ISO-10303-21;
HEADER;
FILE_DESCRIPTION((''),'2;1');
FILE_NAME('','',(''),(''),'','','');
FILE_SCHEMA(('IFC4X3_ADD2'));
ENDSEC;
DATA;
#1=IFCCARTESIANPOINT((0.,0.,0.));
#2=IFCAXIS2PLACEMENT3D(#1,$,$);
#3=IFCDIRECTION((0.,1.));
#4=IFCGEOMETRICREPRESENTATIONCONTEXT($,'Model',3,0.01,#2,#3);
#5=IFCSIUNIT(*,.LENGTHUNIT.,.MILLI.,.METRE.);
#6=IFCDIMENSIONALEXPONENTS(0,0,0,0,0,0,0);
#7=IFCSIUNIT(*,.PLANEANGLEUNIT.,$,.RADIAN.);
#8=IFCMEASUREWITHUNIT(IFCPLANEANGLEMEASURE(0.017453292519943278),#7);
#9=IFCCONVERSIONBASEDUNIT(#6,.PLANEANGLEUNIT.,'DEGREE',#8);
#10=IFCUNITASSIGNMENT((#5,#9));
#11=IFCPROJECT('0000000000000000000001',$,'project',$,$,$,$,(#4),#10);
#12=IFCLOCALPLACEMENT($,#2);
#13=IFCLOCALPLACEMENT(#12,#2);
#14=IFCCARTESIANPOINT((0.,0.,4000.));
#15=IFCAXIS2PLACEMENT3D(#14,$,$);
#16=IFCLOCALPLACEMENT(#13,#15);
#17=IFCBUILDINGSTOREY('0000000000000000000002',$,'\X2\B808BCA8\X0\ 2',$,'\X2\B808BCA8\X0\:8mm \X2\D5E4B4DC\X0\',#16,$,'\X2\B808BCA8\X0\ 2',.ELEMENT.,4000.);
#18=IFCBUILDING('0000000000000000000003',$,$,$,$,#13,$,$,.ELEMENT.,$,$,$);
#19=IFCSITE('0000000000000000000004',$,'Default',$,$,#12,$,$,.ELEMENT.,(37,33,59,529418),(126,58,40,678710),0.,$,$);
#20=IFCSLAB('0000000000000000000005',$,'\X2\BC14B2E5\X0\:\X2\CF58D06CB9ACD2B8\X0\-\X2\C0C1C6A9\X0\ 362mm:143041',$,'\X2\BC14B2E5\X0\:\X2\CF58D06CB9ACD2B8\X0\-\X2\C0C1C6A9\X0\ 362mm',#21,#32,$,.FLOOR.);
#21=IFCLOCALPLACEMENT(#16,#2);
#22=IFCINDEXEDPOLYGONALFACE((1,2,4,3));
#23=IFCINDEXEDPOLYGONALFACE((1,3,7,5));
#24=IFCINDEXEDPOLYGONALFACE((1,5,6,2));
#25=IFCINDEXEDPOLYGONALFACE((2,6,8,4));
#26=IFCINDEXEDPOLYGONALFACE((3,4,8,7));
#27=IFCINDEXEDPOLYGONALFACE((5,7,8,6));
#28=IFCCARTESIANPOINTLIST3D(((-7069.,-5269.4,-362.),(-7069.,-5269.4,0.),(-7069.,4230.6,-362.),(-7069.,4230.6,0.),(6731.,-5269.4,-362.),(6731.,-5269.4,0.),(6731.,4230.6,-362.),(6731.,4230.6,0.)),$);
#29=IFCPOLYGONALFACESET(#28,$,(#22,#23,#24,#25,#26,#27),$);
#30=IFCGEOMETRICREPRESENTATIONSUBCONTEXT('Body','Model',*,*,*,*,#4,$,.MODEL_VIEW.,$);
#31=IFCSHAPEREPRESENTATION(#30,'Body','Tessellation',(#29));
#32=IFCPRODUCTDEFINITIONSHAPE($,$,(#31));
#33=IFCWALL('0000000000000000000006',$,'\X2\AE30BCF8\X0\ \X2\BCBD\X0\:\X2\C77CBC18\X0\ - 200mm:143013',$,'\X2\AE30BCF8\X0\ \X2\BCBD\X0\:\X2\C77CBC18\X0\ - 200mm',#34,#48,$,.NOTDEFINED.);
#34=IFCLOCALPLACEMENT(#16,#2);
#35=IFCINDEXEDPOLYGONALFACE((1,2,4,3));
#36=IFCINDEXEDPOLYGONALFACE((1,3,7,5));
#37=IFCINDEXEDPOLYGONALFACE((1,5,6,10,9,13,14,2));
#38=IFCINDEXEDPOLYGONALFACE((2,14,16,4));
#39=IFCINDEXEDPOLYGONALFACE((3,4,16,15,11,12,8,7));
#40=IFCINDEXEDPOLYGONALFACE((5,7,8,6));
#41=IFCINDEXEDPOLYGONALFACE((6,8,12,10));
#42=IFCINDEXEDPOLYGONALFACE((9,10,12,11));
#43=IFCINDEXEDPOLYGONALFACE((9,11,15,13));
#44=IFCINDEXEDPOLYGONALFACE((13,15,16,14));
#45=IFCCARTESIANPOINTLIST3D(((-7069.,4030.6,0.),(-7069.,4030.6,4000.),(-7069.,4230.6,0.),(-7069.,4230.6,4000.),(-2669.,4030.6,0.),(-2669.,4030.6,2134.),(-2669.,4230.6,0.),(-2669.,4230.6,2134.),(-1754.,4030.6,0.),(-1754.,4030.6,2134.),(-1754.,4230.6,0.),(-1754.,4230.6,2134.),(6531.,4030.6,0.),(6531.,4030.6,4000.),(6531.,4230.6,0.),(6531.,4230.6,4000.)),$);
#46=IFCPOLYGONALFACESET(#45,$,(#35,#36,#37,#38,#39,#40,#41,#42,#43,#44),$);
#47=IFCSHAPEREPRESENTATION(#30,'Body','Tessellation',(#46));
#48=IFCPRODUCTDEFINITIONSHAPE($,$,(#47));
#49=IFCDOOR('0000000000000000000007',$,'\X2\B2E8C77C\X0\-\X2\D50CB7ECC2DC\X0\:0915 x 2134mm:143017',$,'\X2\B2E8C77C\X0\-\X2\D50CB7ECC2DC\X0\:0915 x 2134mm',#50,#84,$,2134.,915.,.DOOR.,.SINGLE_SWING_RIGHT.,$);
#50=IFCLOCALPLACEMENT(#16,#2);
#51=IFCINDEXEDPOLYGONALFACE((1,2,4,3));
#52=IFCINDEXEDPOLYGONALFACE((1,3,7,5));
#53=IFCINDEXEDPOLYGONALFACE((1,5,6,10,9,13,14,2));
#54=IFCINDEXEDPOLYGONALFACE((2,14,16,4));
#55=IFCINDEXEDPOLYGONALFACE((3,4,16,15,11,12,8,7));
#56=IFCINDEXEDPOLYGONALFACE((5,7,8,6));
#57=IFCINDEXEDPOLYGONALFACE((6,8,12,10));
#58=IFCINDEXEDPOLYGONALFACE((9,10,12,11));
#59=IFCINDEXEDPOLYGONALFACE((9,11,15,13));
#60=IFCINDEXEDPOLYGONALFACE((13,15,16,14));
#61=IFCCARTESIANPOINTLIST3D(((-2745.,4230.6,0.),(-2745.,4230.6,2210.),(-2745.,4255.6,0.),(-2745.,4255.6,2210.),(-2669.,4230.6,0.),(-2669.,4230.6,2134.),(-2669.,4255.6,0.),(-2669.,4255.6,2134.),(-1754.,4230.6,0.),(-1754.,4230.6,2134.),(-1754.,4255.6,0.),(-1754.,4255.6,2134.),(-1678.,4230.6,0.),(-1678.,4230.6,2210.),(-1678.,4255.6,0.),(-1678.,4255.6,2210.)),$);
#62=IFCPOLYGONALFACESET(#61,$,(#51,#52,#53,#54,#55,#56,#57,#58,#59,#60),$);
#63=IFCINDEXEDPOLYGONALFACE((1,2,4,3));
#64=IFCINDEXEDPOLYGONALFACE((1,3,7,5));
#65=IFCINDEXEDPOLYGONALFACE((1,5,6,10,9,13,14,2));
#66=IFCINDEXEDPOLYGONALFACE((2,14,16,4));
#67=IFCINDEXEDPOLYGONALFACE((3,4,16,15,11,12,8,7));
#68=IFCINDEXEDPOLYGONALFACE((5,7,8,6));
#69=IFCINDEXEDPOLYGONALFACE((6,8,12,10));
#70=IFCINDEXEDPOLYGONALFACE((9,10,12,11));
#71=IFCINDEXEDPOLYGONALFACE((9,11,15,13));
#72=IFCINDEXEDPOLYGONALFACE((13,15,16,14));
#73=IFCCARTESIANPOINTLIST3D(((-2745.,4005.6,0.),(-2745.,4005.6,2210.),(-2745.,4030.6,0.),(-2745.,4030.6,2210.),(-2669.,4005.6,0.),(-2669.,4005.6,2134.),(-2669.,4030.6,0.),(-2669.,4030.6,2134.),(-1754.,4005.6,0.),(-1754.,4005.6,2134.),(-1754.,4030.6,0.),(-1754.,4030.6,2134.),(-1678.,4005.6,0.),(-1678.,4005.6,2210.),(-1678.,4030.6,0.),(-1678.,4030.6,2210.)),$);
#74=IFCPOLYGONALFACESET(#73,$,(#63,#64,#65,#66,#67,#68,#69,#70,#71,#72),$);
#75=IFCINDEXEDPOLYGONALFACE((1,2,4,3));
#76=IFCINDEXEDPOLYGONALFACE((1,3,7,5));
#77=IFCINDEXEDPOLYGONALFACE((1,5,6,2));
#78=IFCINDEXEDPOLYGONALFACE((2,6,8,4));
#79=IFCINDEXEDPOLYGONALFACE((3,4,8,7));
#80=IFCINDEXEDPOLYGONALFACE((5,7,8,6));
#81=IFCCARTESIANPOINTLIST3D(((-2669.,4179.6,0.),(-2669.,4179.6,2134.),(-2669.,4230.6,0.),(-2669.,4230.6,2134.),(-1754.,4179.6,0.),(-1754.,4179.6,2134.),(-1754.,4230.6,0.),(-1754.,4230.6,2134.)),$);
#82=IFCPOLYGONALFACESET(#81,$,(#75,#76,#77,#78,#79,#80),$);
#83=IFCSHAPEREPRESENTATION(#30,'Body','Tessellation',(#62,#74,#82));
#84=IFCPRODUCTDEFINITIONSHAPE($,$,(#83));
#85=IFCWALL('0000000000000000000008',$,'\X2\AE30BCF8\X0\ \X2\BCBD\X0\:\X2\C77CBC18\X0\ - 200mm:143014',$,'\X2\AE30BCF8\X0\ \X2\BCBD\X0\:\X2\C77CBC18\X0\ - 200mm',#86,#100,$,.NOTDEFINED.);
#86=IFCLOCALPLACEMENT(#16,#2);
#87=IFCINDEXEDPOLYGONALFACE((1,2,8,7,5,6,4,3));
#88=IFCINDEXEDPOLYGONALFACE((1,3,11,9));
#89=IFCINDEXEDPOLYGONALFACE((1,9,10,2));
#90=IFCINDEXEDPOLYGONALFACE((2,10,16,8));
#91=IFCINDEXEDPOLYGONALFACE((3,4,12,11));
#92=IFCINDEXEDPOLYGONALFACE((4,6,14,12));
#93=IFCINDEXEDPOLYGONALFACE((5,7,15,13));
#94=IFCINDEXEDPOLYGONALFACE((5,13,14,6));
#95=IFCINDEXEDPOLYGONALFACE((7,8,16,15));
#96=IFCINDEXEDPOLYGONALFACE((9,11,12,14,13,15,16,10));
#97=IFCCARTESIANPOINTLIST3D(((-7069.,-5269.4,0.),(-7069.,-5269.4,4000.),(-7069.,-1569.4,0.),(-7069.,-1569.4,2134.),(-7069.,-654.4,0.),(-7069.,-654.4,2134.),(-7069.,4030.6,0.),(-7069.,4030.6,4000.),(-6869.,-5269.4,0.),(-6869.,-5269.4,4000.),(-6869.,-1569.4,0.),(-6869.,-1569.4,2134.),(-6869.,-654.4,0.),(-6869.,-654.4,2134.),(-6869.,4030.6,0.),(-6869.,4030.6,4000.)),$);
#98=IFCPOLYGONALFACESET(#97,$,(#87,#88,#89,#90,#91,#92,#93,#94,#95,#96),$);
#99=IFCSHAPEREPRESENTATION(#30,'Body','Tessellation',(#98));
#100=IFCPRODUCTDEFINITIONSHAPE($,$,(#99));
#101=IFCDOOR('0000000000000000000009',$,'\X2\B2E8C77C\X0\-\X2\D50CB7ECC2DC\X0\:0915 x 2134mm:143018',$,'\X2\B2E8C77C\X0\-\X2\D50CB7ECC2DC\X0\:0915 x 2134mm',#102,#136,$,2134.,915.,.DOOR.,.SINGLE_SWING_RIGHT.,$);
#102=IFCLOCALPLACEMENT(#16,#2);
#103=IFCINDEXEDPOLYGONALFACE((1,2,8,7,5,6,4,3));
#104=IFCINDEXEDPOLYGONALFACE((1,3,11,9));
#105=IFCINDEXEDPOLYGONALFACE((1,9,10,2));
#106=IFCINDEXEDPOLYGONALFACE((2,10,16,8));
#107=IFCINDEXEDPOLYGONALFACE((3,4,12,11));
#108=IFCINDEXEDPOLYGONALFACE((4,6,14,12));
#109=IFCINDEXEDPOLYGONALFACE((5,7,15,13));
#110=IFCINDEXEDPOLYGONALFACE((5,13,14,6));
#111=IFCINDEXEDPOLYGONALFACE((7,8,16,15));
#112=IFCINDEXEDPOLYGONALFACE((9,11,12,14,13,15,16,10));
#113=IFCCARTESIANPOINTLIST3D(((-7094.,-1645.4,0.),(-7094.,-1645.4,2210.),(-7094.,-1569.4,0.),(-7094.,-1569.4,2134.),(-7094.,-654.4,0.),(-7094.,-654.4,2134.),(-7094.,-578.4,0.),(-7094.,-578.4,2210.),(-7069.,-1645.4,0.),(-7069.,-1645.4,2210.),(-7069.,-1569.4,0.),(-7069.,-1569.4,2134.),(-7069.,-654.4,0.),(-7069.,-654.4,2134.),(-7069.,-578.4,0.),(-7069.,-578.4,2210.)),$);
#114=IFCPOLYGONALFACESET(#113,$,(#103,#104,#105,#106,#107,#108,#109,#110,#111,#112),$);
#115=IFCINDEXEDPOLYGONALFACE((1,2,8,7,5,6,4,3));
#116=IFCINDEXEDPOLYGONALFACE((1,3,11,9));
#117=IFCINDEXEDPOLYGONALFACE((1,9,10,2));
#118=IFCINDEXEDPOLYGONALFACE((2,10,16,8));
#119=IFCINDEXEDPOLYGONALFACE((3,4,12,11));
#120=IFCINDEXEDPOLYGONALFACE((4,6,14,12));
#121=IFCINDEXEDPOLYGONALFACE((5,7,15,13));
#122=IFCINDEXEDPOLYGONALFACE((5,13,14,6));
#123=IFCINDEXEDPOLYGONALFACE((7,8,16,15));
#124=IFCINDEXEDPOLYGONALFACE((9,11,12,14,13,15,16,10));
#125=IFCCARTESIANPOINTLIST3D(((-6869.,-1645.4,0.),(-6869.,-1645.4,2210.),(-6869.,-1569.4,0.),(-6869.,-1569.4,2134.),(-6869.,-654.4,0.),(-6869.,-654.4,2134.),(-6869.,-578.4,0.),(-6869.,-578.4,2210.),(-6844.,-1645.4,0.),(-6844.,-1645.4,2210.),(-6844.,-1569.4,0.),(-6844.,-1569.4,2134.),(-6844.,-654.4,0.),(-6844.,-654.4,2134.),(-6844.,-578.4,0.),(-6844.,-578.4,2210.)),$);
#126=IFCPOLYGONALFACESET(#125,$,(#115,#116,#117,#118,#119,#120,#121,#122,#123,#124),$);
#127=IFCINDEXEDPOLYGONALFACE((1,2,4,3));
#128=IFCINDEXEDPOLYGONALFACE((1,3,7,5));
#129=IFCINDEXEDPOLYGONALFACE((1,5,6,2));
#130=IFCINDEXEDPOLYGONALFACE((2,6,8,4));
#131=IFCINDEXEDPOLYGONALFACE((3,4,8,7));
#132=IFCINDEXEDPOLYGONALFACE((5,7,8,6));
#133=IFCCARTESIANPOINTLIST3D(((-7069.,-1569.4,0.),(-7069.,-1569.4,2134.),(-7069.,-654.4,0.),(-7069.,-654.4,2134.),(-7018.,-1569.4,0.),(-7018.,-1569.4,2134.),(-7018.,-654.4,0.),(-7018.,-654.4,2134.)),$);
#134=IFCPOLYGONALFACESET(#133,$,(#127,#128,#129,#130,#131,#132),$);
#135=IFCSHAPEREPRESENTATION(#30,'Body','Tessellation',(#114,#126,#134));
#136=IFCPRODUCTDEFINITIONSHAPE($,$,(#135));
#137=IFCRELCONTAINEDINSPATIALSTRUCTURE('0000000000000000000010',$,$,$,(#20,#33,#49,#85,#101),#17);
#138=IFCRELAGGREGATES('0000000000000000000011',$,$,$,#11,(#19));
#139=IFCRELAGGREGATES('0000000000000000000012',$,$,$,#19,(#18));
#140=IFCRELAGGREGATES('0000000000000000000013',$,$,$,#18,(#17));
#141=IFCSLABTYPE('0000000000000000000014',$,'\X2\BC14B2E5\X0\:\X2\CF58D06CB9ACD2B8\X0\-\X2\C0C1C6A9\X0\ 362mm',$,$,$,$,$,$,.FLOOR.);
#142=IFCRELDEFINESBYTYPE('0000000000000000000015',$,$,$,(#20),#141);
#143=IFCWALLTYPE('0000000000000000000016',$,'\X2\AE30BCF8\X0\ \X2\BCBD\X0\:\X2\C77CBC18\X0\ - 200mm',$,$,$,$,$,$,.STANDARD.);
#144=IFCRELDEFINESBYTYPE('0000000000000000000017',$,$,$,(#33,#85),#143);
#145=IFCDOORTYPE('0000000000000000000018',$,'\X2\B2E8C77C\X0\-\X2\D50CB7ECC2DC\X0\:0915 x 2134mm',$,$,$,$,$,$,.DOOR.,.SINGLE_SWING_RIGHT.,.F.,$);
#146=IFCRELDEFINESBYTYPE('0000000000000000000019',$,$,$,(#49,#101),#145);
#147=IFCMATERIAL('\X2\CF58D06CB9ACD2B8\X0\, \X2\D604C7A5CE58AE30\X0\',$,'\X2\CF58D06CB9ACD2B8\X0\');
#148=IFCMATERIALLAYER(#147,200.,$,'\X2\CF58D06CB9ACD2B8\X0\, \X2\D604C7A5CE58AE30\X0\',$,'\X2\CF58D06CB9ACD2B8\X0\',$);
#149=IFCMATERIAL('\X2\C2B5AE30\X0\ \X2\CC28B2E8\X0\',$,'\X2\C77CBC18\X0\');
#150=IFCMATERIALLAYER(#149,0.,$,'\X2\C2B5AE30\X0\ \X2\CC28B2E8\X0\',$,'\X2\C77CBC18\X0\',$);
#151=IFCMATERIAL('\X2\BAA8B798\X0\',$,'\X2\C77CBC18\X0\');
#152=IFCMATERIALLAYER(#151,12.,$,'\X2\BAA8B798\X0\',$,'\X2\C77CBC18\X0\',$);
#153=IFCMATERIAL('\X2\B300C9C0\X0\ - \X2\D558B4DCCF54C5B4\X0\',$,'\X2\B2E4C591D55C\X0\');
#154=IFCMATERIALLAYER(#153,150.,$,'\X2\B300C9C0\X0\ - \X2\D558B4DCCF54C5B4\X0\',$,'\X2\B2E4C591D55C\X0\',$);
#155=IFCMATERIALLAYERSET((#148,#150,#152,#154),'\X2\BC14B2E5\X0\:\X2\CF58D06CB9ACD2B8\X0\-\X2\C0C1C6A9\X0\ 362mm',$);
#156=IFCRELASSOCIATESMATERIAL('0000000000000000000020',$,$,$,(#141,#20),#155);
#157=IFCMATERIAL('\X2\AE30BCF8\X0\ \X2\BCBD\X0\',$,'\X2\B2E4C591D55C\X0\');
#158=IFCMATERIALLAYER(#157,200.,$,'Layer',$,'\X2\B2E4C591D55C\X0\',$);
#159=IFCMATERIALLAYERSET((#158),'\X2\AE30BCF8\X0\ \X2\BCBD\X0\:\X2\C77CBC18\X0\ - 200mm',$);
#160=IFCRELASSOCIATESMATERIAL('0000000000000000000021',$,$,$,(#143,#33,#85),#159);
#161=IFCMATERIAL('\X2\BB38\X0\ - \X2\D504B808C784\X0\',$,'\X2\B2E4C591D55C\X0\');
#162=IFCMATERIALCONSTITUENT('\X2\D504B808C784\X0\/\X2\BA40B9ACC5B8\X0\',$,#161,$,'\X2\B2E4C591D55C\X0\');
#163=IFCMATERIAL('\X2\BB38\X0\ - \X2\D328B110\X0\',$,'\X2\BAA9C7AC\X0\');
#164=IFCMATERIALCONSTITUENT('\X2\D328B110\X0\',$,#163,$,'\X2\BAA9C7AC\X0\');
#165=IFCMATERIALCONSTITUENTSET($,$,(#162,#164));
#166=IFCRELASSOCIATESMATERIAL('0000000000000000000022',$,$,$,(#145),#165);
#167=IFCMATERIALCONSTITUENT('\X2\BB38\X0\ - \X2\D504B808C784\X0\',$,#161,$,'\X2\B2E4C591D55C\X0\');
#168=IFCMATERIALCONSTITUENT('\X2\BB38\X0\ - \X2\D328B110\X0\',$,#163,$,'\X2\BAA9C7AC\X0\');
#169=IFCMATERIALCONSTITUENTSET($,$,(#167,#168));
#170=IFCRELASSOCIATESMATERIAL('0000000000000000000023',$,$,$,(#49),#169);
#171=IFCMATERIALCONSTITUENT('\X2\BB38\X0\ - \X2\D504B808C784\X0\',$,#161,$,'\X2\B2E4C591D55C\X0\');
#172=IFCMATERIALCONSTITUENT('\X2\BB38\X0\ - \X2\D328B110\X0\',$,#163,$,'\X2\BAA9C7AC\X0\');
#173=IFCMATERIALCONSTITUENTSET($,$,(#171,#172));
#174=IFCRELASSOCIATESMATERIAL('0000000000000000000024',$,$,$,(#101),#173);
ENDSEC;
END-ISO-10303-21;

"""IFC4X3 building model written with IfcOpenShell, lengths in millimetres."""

from ifc_helpers import new_model, entity, si_unit, converted_unit, direction, frame, frame_2d, origin, origin_2d_with_axis, place, context, subcontext, project, spatial, polyline, rectangle, outline, extrude, source, transform, mapped, material, layer, layer_set, layer_usage, constituent, constituent_set, type_object, type_shapes, element, fill, save


model = new_model("IFC4X3")

# Units and contexts
model_context = context("Model", 3, precision=0.01, world=origin(), true_north=direction((0.0, 1.0)))
body_context = subcontext(model_context, "Body", "Model", "MODEL_VIEW")
ifc_project = project(units=[si_unit("LENGTHUNIT", "METRE", prefix="MILLI"), converted_unit("PLANEANGLEUNIT", "DEGREE", entity("IfcPlaneAngleMeasure", 0.017453292519943278), si_unit("PLANEANGLEUNIT", "RADIAN"), dimensions=[0, 0, 0, 0, 0, 0, 0])], contexts=[model_context])

# Site, building, storey
site_placement = place(None, origin())
site = spatial("IfcSite", under=ifc_project, at=site_placement, Name="Default", CompositionType="ELEMENT", RefLatitude=(37, 33, 59, 529418), RefLongitude=(126, 58, 40, 678710), RefElevation=0.0)
building_placement = place(site_placement, origin())
building = spatial("IfcBuilding", under=site, at=building_placement, CompositionType="ELEMENT")
storey_placement = place(building_placement, frame((0.0, 0.0, 4000.0)))
storey = spatial("IfcBuildingStorey", under=building, at=storey_placement, Name="레벨 2", ObjectType="레벨:8mm 헤드", LongName="레벨 2", CompositionType="ELEMENT", Elevation=4000.0)

# Slab
ifc_material_1 = material(Name="콘크리트, 현장치기", Category="콘크리트")
ifc_layer_1 = layer(ifc_material_1, 200.0, Name="콘크리트, 현장치기", Category="콘크리트")
ifc_material_2 = material(Name="습기 차단", Category="일반")
ifc_layer_2 = layer(ifc_material_2, 0.0, Name="습기 차단", Category="일반")
ifc_material_3 = material(Name="모래", Category="일반")
ifc_layer_3 = layer(ifc_material_3, 12.0, Name="모래", Category="일반")
ifc_material_4 = material(Name="대지 - 하드코어", Category="다양한")
ifc_layer_4 = layer(ifc_material_4, 150.0, Name="대지 - 하드코어", Category="다양한")
ifc_layer_set_1 = layer_set([ifc_layer_1, ifc_layer_2, ifc_layer_3, ifc_layer_4], Name="바닥:콘크리트-상용 362mm")
ifc_layer_usage_1 = layer_usage(ifc_layer_set_1, "AXIS3", "POSITIVE", 0.0)
slab_type = type_object("IfcSlabType", Name="바닥:콘크리트-상용 362mm", PredefinedType="FLOOR", material=ifc_layer_set_1)
slab_placement = place(storey_placement, origin())
element("IfcSlab", 1, at=slab_placement, inside=storey, type_object=slab_type, material=ifc_layer_usage_1, Name="바닥:콘크리트-상용 362mm:143041", ObjectType="바닥:콘크리트-상용 362mm", PredefinedType="FLOOR", context=body_context, shape_type="SweptSolid", body=[
    extrude(rectangle(XDim=9500.0, YDim=13800.0, at=origin_2d_with_axis()), frame((-169.0, -519.4, 0.0), z_axis=(0.0, 0.0, -1.0), x_axis=(0.0, 1.0, 0.0)), (0.0, 0.0, 1.0), 362.0),
])

# Walls, openings, doors
ifc_material_5 = material(Name="기본 벽", Category="다양한")
ifc_layer_5 = layer(ifc_material_5, 200.0, Name="Layer", Category="다양한")
ifc_layer_set_2 = layer_set([ifc_layer_5], Name="기본 벽:일반 - 200mm")
wall_type = type_object("IfcWallType", Name="기본 벽:일반 - 200mm", PredefinedType="STANDARD", material=ifc_layer_set_2)
wall_1_placement = place(storey_placement, frame((-7069.0, 4130.6, 0.0)))
wall_1 = element("IfcWall", 2, at=wall_1_placement, inside=storey, type_object=wall_type, material=ifc_layer_set_2, Name="기본 벽:일반 - 200mm:143013", ObjectType="기본 벽:일반 - 200mm", PredefinedType="NOTDEFINED", context=body_context, shape_type="SweptSolid", body=[
    extrude(rectangle(XDim=13600.0, YDim=200.0, at=frame_2d((6800.0, 0.0), x_axis=(1.0, 0.0))), origin(), (0.0, 0.0, 1.0), 4000.0),
])
opening_1_placement = place(wall_1_placement, frame((4400.0, -100.0, 0.0)))
opening_1 = element("IfcOpeningElement", 3, at=opening_1_placement, cuts=wall_1, PredefinedType="OPENING", context=body_context, shape_type="SweptSolid", body=[
    extrude(rectangle(XDim=915.0, YDim=2134.0, at=frame_2d((1067.0, 457.5), x_axis=(0.0, 1.0))), frame((0.0, 0.0, 0.0), z_axis=(0.0, 1.0, 0.0), x_axis=(0.0, 0.0, 1.0)), (0.0, 0.0, 1.0), 200.0),
])
ifc_material_6 = material(Name="문 - 프레임", Category="다양한")
ifc_constituent_1 = constituent(ifc_material_6, Name="문 - 프레임", Category="다양한")
ifc_material_7 = material(Name="문 - 패널", Category="목재")
ifc_constituent_2 = constituent(ifc_material_7, Name="문 - 패널", Category="목재")
ifc_constituent_set_1 = constituent_set(constituents=[ifc_constituent_1, ifc_constituent_2])
ifc_constituent_3 = constituent(ifc_material_6, Name="프레임/멀리언", Category="다양한")
ifc_constituent_4 = constituent(ifc_material_7, Name="패널", Category="목재")
ifc_constituent_set_2 = constituent_set(constituents=[ifc_constituent_3, ifc_constituent_4])
door_type = type_object("IfcDoorType", Name="단일-플러시:0915 x 2134mm", OperationType="SINGLE_SWING_RIGHT", ParameterTakesPrecedence=False, PredefinedType="DOOR", material=ifc_constituent_set_2)
shared_shape_1 = source(origin(), body_context, "Body", "SweptSolid", [
    extrude(outline(polyline([(-533.5, -1124.0), (533.5, -1124.0), (533.5, 1086.0), (457.5, 1086.0), (457.5, -1048.0), (-457.5, -1048.0), (-457.5, 1086.0), (-533.5, 1086.0), (-533.5, -1124.0)])), frame((457.5, 200.0, 1086.0), z_axis=(0.0, 1.0, 0.0), x_axis=(1.0, 0.0, 0.0)), (0.0, 0.0, 1.0), 25.0),
    extrude(outline(polyline([(-1124.0, -533.5), (1086.0, -533.5), (1086.0, -457.5), (-1048.0, -457.5), (-1048.0, 457.5), (1086.0, 457.5), (1086.0, 533.5), (-1124.0, 533.5), (-1124.0, -533.5)])), frame((457.5, -25.0, 1086.0), z_axis=(0.0, 1.0, 0.0), x_axis=(0.0, 0.0, -1.0)), (0.0, 0.0, 1.0), 25.0),
    extrude(rectangle(XDim=51.0, YDim=915.0, at=frame_2d((0.0, 0.0), x_axis=(1.0, 0.0))), frame((457.5, 174.5, 0.0), z_axis=(0.0, 0.0, 1.0), x_axis=(0.0, 1.0, 0.0)), (0.0, 0.0, 1.0), 2134.0),
])
type_shapes(door_type, [shared_shape_1])
door_1_placement = place(opening_1_placement, origin())
door_1 = element("IfcDoor", 4, at=door_1_placement, inside=storey, type_object=door_type, material=ifc_constituent_set_1, Name="단일-플러시:0915 x 2134mm:143017", ObjectType="단일-플러시:0915 x 2134mm", OperationType="SINGLE_SWING_RIGHT", OverallHeight=2134.0, OverallWidth=915.0, PredefinedType="DOOR", context=body_context, shape_type="MappedRepresentation", body=[
    mapped(shared_shape_1, transform((0.0, 0.0, 0.0), scale=1.0)),
])
fill(opening_1, door_1)
wall_2_placement = place(storey_placement, frame((-6969.0, -5269.4, 0.0), z_axis=(0.0, 0.0, 1.0), x_axis=(0.0, 1.0, 0.0)))
wall_2 = element("IfcWall", 5, at=wall_2_placement, inside=storey, type_object=wall_type, material=ifc_layer_set_2, Name="기본 벽:일반 - 200mm:143014", ObjectType="기본 벽:일반 - 200mm", PredefinedType="NOTDEFINED", context=body_context, shape_type="SweptSolid", body=[
    extrude(rectangle(XDim=9300.0, YDim=200.0, at=frame_2d((4650.0, 0.0), x_axis=(1.0, 0.0))), origin(), (0.0, 0.0, 1.0), 4000.0),
])
opening_2_placement = place(wall_2_placement, frame((3700.0, -100.0, 0.0)))
opening_2 = element("IfcOpeningElement", 6, at=opening_2_placement, cuts=wall_2, PredefinedType="OPENING", context=body_context, shape_type="SweptSolid", body=[
    extrude(rectangle(XDim=915.0, YDim=2134.0, at=frame_2d((1067.0, 457.5), x_axis=(0.0, 1.0))), frame((0.0, 0.0, 0.0), z_axis=(0.0, 1.0, 0.0), x_axis=(0.0, 0.0, 1.0)), (0.0, 0.0, 1.0), 200.0),
])
ifc_constituent_5 = constituent(ifc_material_6, Name="문 - 프레임", Category="다양한")
ifc_constituent_6 = constituent(ifc_material_7, Name="문 - 패널", Category="목재")
ifc_constituent_set_3 = constituent_set(constituents=[ifc_constituent_5, ifc_constituent_6])
door_2_placement = place(opening_2_placement, origin())
door_2 = element("IfcDoor", 7, at=door_2_placement, inside=storey, type_object=door_type, material=ifc_constituent_set_3, Name="단일-플러시:0915 x 2134mm:143018", ObjectType="단일-플러시:0915 x 2134mm", OperationType="SINGLE_SWING_RIGHT", OverallHeight=2134.0, OverallWidth=915.0, PredefinedType="DOOR", context=body_context, shape_type="MappedRepresentation", body=[
    mapped(shared_shape_1, transform((0.0, 0.0, 0.0), scale=1.0)),
])
fill(opening_2, door_2)

save(model, "model.ifc")
